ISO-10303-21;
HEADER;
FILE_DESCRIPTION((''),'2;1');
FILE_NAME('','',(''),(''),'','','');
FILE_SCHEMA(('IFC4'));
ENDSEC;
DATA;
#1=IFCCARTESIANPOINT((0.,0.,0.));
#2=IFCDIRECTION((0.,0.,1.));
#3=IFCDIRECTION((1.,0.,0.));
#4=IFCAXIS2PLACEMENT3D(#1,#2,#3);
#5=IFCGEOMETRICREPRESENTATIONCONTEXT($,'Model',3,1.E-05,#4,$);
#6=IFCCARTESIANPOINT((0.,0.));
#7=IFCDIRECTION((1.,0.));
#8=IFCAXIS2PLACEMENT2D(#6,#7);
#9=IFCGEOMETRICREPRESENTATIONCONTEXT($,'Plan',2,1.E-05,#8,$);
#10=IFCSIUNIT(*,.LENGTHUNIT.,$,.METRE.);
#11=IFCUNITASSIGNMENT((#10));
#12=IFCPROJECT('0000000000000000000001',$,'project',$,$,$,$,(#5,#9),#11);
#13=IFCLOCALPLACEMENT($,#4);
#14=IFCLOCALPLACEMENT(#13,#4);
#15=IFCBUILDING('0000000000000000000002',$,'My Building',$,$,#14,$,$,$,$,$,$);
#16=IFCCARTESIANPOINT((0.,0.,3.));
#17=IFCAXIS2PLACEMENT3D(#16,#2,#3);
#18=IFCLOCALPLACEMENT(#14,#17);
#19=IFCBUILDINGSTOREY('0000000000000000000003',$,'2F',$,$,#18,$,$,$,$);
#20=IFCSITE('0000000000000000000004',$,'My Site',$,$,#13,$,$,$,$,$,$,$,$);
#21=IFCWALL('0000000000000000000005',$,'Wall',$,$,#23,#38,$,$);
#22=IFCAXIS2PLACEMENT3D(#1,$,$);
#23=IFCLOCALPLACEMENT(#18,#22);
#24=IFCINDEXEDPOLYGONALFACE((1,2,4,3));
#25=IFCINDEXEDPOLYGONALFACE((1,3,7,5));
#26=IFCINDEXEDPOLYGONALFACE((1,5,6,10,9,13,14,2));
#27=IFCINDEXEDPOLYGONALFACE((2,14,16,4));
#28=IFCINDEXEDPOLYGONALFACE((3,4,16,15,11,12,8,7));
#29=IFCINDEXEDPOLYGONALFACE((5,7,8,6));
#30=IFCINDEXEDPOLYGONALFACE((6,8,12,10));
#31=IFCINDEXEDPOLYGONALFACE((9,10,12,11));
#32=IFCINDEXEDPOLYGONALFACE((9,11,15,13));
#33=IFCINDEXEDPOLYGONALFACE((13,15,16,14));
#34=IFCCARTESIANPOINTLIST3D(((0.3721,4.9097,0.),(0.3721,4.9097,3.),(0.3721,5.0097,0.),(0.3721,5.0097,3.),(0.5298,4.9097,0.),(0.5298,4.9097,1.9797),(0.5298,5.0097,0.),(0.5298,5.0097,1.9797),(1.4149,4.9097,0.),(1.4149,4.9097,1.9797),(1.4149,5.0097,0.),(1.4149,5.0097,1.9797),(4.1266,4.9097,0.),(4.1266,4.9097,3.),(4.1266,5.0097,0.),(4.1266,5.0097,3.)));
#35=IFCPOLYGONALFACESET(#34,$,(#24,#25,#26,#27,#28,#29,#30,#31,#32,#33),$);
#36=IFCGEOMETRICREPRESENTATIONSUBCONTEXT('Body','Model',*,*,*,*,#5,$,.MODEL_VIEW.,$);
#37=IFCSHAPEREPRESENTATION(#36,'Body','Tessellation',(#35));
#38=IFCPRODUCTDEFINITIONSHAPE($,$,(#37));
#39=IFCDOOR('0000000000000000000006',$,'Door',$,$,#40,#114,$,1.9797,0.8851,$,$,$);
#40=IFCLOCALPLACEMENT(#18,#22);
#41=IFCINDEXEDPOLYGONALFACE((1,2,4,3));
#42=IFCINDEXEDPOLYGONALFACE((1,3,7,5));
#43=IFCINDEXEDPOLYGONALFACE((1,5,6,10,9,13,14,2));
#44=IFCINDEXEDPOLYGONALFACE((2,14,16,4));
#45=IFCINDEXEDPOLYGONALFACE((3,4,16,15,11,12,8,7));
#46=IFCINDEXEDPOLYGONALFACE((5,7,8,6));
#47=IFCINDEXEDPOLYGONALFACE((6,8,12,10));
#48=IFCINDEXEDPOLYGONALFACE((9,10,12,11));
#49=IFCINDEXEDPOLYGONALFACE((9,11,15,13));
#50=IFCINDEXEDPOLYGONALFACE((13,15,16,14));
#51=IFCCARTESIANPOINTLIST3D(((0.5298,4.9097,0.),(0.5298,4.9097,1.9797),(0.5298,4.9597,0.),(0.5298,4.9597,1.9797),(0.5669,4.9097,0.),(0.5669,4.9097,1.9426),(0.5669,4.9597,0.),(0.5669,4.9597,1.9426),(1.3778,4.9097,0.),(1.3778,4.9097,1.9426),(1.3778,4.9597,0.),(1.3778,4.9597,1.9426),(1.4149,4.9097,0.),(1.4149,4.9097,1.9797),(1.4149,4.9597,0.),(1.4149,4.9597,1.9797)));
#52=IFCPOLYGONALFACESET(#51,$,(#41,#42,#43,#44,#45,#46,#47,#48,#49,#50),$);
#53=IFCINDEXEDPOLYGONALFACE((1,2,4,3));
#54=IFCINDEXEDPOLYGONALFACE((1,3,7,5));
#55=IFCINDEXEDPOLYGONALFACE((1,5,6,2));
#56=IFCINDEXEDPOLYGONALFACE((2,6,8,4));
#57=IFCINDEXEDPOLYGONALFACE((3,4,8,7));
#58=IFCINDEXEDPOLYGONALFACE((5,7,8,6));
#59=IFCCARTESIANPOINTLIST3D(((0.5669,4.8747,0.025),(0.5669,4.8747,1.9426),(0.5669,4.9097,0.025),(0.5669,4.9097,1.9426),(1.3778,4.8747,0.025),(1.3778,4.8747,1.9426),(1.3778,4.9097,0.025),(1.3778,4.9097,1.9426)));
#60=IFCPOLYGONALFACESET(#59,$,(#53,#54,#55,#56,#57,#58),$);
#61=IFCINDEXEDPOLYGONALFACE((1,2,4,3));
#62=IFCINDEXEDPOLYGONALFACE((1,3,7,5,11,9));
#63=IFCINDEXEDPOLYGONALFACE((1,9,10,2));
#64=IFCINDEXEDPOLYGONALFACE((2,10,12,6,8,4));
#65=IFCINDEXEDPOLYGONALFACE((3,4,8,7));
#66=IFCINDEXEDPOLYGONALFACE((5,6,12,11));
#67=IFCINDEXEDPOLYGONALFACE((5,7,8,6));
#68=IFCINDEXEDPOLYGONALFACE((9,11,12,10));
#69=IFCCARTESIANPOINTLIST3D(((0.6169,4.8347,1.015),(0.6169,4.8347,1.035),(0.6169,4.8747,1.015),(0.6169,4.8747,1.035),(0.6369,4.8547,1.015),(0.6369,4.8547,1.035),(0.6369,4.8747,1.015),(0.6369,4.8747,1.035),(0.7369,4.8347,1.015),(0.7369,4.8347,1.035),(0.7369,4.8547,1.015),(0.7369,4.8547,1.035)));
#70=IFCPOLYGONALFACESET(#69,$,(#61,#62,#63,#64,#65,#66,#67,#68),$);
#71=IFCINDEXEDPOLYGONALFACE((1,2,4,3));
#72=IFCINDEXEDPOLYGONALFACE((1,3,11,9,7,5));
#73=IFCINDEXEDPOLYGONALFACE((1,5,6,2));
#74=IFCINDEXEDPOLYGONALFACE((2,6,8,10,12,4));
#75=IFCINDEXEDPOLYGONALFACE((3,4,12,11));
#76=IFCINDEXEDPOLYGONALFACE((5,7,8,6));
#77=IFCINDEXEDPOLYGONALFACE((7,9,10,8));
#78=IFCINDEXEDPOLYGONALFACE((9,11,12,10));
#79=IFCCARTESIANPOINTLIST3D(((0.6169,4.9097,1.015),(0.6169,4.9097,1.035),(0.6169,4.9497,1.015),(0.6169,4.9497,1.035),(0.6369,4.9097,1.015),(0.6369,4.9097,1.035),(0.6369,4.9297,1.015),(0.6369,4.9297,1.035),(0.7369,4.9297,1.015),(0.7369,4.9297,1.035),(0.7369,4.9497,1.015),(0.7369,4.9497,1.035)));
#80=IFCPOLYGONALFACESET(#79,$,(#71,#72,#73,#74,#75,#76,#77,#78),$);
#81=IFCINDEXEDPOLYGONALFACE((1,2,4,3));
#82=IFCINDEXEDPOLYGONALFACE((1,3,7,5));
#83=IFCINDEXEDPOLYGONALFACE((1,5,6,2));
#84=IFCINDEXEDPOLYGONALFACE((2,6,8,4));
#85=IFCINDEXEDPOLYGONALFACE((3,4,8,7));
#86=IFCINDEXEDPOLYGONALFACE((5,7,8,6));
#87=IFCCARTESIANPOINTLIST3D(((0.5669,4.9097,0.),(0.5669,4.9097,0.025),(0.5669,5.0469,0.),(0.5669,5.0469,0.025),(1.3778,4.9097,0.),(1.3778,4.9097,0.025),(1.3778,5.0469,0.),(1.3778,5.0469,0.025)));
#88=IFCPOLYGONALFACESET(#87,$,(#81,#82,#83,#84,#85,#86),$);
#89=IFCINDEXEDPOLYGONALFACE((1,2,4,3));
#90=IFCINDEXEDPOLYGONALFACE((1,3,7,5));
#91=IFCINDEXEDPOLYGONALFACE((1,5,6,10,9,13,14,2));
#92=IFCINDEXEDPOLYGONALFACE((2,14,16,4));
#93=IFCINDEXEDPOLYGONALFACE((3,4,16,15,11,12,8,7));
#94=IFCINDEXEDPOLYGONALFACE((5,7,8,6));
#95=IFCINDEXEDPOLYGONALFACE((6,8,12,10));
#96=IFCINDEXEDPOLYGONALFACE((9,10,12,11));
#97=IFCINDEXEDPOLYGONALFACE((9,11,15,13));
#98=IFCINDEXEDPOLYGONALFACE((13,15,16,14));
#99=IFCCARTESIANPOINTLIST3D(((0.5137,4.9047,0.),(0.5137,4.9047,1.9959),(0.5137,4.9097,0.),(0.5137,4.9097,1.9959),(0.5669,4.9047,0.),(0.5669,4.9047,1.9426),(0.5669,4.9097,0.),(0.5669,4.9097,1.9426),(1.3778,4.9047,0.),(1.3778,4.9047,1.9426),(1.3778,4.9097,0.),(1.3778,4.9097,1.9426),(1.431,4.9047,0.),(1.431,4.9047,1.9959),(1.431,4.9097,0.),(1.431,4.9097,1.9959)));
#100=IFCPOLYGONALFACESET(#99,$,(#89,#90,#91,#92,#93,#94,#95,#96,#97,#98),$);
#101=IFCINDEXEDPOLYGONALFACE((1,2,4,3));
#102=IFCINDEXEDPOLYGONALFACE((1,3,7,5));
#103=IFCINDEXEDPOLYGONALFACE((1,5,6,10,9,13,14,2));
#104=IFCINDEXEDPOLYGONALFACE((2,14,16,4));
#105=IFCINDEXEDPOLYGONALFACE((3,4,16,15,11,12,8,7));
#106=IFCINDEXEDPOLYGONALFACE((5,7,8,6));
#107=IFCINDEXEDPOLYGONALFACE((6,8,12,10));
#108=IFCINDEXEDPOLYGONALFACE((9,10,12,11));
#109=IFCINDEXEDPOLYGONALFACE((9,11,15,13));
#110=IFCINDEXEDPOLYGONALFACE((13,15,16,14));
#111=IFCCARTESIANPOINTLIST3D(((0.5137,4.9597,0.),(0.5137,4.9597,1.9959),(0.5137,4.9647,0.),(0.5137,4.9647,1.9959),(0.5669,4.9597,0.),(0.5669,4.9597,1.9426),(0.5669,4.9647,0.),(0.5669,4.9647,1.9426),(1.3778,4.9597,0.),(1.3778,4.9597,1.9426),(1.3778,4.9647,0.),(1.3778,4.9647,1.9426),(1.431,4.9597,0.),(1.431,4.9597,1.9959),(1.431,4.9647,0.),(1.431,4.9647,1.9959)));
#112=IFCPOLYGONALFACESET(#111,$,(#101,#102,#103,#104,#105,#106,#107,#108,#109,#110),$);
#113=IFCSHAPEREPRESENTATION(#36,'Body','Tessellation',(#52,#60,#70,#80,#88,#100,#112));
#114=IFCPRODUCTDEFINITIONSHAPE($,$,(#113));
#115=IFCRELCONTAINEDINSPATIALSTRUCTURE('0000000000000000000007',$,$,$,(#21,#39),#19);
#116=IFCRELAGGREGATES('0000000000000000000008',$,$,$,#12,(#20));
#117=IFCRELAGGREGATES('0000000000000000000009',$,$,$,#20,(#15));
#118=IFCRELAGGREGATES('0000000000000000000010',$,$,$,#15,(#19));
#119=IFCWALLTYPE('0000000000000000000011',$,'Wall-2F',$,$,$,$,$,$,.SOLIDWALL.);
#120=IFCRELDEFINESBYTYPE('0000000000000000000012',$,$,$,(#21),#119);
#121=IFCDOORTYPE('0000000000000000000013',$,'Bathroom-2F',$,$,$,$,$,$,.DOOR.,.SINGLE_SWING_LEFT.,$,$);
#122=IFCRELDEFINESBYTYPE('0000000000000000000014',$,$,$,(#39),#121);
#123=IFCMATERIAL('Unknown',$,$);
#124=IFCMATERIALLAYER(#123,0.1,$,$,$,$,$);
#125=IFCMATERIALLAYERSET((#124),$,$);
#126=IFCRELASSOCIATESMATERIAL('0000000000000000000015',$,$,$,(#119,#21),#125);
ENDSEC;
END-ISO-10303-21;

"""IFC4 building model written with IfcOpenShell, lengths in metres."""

from ifc_helpers import new_model, entity, si_unit, frame, origin_with_axes, origin_2d_with_axis, place, context, subcontext, project, spatial, line, indexed_curve, outline, extrude, shape, source, transform, mapped, material, layer, layer_set, layer_usage, type_object, type_shapes, element, fill, save


model = new_model("IFC4")

# Units and contexts
model_context = context("Model", 3, precision=1e-05, world=origin_with_axes())
plan_context = context("Plan", 2, precision=1e-05, world=origin_2d_with_axis())
body_context_1 = subcontext(model_context, "Body", "Model", "MODEL_VIEW")
body_context_2 = subcontext(plan_context, "Body", "Plan", "PLAN_VIEW")
ifc_project = project(units=[si_unit("LENGTHUNIT", "METRE")], contexts=[model_context, plan_context])

# Site, building, storey
site_placement = place(None, origin_with_axes())
site = spatial("IfcSite", under=ifc_project, at=site_placement, Name="My Site")
building_placement = place(site_placement, origin_with_axes())
building = spatial("IfcBuilding", under=site, at=building_placement, Name="My Building")
storey_placement = place(building_placement, frame((0.0, 0.0, 3.0), z_axis=(0.0, 0.0, 1.0), x_axis=(1.0, 0.0, 0.0)))
storey = spatial("IfcBuildingStorey", under=building, at=storey_placement, Name="2F")

# Shared definitions
ifc_material = material(Name="Unknown")

# Shared definitions
ifc_layer_1 = layer(ifc_material, 0.1)
ifc_layer_set_1 = layer_set([ifc_layer_1])
wall_type = type_object("IfcWallType", Name="Wall-2F", PredefinedType="SOLIDWALL", material=ifc_layer_set_1)

# Wall, opening, door
ifc_layer_usage_1 = layer_usage(ifc_layer_set_1, "AXIS2", "POSITIVE", 0.0)
wall_1_placement = place(storey_placement, frame((4.1266, 5.0097, 0.0), z_axis=(0.0, 0.0, 1.0), x_axis=(-1.0, 0.0, 0.0)))
wall_1 = element("IfcWall", 1, at=wall_1_placement, inside=storey, type_object=wall_type, material=ifc_layer_usage_1, Name="Wall", context=body_context_1, shape_type="SweptSolid", body=[
    extrude(outline(indexed_curve([(0.0, 0.0), (0.0, 0.1), (3.7545, 0.1), (3.7545, 0.0)], segments=[line(1, 2, 3, 4, 1)])), origin_with_axes(), (0.0, 0.0, 1.0), 3.0),
])
shared_shape_1 = source(origin_with_axes(), body_context_1, "Body", "SweptSolid", [
    extrude(outline(indexed_curve([(0.0, 0.0), (0.8851, 0.0), (0.8851, 1.9797), (0.0, 1.9797)], segments=[line(1, 2, 3, 4, 1)])), frame((0.0, -0.6, 0.0), z_axis=(0.0, -1.0, 0.0), x_axis=(1.0, 0.0, 0.0)), (0.0, 0.0, -1.0), 1.2),
])
opening_1_placement = place(wall_1_placement, frame((3.5967, 0.1, 0.0), z_axis=(0.0, 0.0, 1.0), x_axis=(-1.0, 0.0, 0.0)))
opening_1 = element("IfcOpeningElement", 2, at=opening_1_placement, cuts=wall_1, PredefinedType="OPENING", context=body_context_1, shape_type="MappedRepresentation", body=[
    mapped(shared_shape_1, transform((0.0, 0.0, 0.0), x_axis=(1.0, 0.0, 0.0), y_axis=(0.0, 1.0, 0.0), z_axis=(0.0, 0.0, 1.0), scale=1.0)),
])
door_type_1 = type_object("IfcDoorType", Name="Bathroom-2F", OperationType="SINGLE_SWING_LEFT", PredefinedType="DOOR")
shared_shape_2 = source(origin_with_axes(), body_context_1, "Body", "SweptSolid", [
    extrude(outline(indexed_curve([(0.0, 0.0), (0.0, 1.9797), (0.8851, 1.9797), (0.8851, 0.0), (0.848, 0.0), (0.848, 1.9426), (0.0371, 1.9426), (0.0371, 0.0)], segments=[line(1, 2, 3, 4, 5, 6, 7, 8, 1)])), frame((0.0, 0.0, 0.0), z_axis=(0.0, -1.0, 0.0), x_axis=(1.0, 0.0, 0.0)), (0.0, 0.0, -1.0), 0.05),
    extrude(outline(indexed_curve([(0.0, 0.0), (0.8109, 0.0), (0.8109, 0.035), (0.0, 0.035)], segments=[line(1, 2, 3, 4, 1)])), frame((0.0371, -0.035, 0.025), z_axis=(0.0, 0.0, 1.0), x_axis=(1.0, 0.0, 0.0)), (0.0, 0.0, 1.0), 1.9176),
    extrude(outline(indexed_curve([(0.0, 0.0), (0.0, -0.04), (0.12, -0.04), (0.12, -0.02), (0.02, -0.02), (0.02, 0.0)], segments=[line(1, 2, 3, 4, 5, 6, 1)])), frame((0.0871, -0.035, 1.015), z_axis=(0.0, 0.0, 1.0), x_axis=(1.0, 0.0, 0.0)), (0.0, 0.0, 1.0), 0.02),
    extrude(outline(indexed_curve([(0.0, 0.0), (0.0, 0.04), (0.12, 0.04), (0.12, 0.02), (0.02, 0.02), (0.02, 0.0)], segments=[line(1, 2, 3, 4, 5, 6, 1)])), frame((0.0871, 0.0, 1.015), z_axis=(0.0, 0.0, 1.0), x_axis=(1.0, 0.0, 0.0)), (0.0, 0.0, 1.0), 0.02),
    extrude(outline(indexed_curve([(0.0, 0.0), (0.8109, 0.0), (0.8109, 0.1372), (0.0, 0.1372)], segments=[line(1, 2, 3, 4, 1)])), frame((0.0371, 0.0, 0.0), z_axis=(0.0, 0.0, 1.0), x_axis=(1.0, 0.0, 0.0)), (0.0, 0.0, 1.0), 0.025),
    extrude(outline(indexed_curve([(0.0, 0.0), (0.0, 1.9959), (0.9174, 1.9959), (0.9174, 0.0), (0.8641, 0.0), (0.8641, 1.9426), (0.0532, 1.9426), (0.0532, 0.0)], segments=[line(1, 2, 3, 4, 5, 6, 7, 8, 1)])), frame((-0.0162, -0.005, 0.0), z_axis=(0.0, -1.0, 0.0), x_axis=(1.0, 0.0, 0.0)), (0.0, 0.0, -1.0), 0.005),
    extrude(outline(indexed_curve([(0.0, 0.0), (0.0, 1.9959), (0.9174, 1.9959), (0.9174, 0.0), (0.8641, 0.0), (0.8641, 1.9426), (0.0532, 1.9426), (0.0532, 0.0)], segments=[line(1, 2, 3, 4, 5, 6, 7, 8, 1)])), frame((-0.0162, 0.05, 0.0), z_axis=(0.0, -1.0, 0.0), x_axis=(1.0, 0.0, 0.0)), (0.0, 0.0, -1.0), 0.005),
])
shared_shape_3 = source(origin_with_axes(), body_context_2, "Body", "Curve2D", [
    entity("IfcIndexedPolyCurve", entity("IfcCartesianPointList2D", [[0.0, 0.0], [0.0371, 0.0], [0.0371, 0.05], [0.0, 0.05]]), [entity("IfcLineIndex", [1, 2, 3, 4, 1])]),
    entity("IfcIndexedPolyCurve", entity("IfcCartesianPointList2D", [[0.8851, 0.0], [0.848, 0.0], [0.848, 0.05], [0.8851, 0.05]]), [entity("IfcLineIndex", [1, 2, 3, 4, 1])]),
    entity("IfcIndexedPolyCurve", entity("IfcCartesianPointList2D", [[1.2534, -0.035], [0.4425, -0.035], [0.4425, 0.0], [1.2534, 0.0]]), [entity("IfcLineIndex", [1, 2, 3, 4, 1])]),
])
type_shapes(door_type_1, [shared_shape_2, shared_shape_3])
door_1_placement = place(opening_1_placement, frame((0.0, 0.0, 0.0), z_axis=(0.0, 0.0, 1.0), x_axis=(1.0, 0.0, 0.0)))
door_1 = element("IfcDoor", 3, at=door_1_placement, inside=storey, type_object=door_type_1, Name="Door", OverallHeight=1.9797, OverallWidth=0.8851, shapes=[
    shape(body_context_1, "Body", "MappedRepresentation", [mapped(shared_shape_2, transform((0.0, 0.0, 0.0), x_axis=(1.0, 0.0, 0.0), y_axis=(0.0, 1.0, 0.0), z_axis=(0.0, 0.0, 1.0), scale=1.0))]),
    shape(body_context_2, "Body", "MappedRepresentation", [mapped(shared_shape_3, transform((0.0, 0.0, 0.0), x_axis=(1.0, 0.0, 0.0), y_axis=(0.0, 1.0, 0.0), z_axis=(0.0, 0.0, 1.0), scale=1.0))]),
])
fill(opening_1, door_1)

save(model, "model.ifc")
